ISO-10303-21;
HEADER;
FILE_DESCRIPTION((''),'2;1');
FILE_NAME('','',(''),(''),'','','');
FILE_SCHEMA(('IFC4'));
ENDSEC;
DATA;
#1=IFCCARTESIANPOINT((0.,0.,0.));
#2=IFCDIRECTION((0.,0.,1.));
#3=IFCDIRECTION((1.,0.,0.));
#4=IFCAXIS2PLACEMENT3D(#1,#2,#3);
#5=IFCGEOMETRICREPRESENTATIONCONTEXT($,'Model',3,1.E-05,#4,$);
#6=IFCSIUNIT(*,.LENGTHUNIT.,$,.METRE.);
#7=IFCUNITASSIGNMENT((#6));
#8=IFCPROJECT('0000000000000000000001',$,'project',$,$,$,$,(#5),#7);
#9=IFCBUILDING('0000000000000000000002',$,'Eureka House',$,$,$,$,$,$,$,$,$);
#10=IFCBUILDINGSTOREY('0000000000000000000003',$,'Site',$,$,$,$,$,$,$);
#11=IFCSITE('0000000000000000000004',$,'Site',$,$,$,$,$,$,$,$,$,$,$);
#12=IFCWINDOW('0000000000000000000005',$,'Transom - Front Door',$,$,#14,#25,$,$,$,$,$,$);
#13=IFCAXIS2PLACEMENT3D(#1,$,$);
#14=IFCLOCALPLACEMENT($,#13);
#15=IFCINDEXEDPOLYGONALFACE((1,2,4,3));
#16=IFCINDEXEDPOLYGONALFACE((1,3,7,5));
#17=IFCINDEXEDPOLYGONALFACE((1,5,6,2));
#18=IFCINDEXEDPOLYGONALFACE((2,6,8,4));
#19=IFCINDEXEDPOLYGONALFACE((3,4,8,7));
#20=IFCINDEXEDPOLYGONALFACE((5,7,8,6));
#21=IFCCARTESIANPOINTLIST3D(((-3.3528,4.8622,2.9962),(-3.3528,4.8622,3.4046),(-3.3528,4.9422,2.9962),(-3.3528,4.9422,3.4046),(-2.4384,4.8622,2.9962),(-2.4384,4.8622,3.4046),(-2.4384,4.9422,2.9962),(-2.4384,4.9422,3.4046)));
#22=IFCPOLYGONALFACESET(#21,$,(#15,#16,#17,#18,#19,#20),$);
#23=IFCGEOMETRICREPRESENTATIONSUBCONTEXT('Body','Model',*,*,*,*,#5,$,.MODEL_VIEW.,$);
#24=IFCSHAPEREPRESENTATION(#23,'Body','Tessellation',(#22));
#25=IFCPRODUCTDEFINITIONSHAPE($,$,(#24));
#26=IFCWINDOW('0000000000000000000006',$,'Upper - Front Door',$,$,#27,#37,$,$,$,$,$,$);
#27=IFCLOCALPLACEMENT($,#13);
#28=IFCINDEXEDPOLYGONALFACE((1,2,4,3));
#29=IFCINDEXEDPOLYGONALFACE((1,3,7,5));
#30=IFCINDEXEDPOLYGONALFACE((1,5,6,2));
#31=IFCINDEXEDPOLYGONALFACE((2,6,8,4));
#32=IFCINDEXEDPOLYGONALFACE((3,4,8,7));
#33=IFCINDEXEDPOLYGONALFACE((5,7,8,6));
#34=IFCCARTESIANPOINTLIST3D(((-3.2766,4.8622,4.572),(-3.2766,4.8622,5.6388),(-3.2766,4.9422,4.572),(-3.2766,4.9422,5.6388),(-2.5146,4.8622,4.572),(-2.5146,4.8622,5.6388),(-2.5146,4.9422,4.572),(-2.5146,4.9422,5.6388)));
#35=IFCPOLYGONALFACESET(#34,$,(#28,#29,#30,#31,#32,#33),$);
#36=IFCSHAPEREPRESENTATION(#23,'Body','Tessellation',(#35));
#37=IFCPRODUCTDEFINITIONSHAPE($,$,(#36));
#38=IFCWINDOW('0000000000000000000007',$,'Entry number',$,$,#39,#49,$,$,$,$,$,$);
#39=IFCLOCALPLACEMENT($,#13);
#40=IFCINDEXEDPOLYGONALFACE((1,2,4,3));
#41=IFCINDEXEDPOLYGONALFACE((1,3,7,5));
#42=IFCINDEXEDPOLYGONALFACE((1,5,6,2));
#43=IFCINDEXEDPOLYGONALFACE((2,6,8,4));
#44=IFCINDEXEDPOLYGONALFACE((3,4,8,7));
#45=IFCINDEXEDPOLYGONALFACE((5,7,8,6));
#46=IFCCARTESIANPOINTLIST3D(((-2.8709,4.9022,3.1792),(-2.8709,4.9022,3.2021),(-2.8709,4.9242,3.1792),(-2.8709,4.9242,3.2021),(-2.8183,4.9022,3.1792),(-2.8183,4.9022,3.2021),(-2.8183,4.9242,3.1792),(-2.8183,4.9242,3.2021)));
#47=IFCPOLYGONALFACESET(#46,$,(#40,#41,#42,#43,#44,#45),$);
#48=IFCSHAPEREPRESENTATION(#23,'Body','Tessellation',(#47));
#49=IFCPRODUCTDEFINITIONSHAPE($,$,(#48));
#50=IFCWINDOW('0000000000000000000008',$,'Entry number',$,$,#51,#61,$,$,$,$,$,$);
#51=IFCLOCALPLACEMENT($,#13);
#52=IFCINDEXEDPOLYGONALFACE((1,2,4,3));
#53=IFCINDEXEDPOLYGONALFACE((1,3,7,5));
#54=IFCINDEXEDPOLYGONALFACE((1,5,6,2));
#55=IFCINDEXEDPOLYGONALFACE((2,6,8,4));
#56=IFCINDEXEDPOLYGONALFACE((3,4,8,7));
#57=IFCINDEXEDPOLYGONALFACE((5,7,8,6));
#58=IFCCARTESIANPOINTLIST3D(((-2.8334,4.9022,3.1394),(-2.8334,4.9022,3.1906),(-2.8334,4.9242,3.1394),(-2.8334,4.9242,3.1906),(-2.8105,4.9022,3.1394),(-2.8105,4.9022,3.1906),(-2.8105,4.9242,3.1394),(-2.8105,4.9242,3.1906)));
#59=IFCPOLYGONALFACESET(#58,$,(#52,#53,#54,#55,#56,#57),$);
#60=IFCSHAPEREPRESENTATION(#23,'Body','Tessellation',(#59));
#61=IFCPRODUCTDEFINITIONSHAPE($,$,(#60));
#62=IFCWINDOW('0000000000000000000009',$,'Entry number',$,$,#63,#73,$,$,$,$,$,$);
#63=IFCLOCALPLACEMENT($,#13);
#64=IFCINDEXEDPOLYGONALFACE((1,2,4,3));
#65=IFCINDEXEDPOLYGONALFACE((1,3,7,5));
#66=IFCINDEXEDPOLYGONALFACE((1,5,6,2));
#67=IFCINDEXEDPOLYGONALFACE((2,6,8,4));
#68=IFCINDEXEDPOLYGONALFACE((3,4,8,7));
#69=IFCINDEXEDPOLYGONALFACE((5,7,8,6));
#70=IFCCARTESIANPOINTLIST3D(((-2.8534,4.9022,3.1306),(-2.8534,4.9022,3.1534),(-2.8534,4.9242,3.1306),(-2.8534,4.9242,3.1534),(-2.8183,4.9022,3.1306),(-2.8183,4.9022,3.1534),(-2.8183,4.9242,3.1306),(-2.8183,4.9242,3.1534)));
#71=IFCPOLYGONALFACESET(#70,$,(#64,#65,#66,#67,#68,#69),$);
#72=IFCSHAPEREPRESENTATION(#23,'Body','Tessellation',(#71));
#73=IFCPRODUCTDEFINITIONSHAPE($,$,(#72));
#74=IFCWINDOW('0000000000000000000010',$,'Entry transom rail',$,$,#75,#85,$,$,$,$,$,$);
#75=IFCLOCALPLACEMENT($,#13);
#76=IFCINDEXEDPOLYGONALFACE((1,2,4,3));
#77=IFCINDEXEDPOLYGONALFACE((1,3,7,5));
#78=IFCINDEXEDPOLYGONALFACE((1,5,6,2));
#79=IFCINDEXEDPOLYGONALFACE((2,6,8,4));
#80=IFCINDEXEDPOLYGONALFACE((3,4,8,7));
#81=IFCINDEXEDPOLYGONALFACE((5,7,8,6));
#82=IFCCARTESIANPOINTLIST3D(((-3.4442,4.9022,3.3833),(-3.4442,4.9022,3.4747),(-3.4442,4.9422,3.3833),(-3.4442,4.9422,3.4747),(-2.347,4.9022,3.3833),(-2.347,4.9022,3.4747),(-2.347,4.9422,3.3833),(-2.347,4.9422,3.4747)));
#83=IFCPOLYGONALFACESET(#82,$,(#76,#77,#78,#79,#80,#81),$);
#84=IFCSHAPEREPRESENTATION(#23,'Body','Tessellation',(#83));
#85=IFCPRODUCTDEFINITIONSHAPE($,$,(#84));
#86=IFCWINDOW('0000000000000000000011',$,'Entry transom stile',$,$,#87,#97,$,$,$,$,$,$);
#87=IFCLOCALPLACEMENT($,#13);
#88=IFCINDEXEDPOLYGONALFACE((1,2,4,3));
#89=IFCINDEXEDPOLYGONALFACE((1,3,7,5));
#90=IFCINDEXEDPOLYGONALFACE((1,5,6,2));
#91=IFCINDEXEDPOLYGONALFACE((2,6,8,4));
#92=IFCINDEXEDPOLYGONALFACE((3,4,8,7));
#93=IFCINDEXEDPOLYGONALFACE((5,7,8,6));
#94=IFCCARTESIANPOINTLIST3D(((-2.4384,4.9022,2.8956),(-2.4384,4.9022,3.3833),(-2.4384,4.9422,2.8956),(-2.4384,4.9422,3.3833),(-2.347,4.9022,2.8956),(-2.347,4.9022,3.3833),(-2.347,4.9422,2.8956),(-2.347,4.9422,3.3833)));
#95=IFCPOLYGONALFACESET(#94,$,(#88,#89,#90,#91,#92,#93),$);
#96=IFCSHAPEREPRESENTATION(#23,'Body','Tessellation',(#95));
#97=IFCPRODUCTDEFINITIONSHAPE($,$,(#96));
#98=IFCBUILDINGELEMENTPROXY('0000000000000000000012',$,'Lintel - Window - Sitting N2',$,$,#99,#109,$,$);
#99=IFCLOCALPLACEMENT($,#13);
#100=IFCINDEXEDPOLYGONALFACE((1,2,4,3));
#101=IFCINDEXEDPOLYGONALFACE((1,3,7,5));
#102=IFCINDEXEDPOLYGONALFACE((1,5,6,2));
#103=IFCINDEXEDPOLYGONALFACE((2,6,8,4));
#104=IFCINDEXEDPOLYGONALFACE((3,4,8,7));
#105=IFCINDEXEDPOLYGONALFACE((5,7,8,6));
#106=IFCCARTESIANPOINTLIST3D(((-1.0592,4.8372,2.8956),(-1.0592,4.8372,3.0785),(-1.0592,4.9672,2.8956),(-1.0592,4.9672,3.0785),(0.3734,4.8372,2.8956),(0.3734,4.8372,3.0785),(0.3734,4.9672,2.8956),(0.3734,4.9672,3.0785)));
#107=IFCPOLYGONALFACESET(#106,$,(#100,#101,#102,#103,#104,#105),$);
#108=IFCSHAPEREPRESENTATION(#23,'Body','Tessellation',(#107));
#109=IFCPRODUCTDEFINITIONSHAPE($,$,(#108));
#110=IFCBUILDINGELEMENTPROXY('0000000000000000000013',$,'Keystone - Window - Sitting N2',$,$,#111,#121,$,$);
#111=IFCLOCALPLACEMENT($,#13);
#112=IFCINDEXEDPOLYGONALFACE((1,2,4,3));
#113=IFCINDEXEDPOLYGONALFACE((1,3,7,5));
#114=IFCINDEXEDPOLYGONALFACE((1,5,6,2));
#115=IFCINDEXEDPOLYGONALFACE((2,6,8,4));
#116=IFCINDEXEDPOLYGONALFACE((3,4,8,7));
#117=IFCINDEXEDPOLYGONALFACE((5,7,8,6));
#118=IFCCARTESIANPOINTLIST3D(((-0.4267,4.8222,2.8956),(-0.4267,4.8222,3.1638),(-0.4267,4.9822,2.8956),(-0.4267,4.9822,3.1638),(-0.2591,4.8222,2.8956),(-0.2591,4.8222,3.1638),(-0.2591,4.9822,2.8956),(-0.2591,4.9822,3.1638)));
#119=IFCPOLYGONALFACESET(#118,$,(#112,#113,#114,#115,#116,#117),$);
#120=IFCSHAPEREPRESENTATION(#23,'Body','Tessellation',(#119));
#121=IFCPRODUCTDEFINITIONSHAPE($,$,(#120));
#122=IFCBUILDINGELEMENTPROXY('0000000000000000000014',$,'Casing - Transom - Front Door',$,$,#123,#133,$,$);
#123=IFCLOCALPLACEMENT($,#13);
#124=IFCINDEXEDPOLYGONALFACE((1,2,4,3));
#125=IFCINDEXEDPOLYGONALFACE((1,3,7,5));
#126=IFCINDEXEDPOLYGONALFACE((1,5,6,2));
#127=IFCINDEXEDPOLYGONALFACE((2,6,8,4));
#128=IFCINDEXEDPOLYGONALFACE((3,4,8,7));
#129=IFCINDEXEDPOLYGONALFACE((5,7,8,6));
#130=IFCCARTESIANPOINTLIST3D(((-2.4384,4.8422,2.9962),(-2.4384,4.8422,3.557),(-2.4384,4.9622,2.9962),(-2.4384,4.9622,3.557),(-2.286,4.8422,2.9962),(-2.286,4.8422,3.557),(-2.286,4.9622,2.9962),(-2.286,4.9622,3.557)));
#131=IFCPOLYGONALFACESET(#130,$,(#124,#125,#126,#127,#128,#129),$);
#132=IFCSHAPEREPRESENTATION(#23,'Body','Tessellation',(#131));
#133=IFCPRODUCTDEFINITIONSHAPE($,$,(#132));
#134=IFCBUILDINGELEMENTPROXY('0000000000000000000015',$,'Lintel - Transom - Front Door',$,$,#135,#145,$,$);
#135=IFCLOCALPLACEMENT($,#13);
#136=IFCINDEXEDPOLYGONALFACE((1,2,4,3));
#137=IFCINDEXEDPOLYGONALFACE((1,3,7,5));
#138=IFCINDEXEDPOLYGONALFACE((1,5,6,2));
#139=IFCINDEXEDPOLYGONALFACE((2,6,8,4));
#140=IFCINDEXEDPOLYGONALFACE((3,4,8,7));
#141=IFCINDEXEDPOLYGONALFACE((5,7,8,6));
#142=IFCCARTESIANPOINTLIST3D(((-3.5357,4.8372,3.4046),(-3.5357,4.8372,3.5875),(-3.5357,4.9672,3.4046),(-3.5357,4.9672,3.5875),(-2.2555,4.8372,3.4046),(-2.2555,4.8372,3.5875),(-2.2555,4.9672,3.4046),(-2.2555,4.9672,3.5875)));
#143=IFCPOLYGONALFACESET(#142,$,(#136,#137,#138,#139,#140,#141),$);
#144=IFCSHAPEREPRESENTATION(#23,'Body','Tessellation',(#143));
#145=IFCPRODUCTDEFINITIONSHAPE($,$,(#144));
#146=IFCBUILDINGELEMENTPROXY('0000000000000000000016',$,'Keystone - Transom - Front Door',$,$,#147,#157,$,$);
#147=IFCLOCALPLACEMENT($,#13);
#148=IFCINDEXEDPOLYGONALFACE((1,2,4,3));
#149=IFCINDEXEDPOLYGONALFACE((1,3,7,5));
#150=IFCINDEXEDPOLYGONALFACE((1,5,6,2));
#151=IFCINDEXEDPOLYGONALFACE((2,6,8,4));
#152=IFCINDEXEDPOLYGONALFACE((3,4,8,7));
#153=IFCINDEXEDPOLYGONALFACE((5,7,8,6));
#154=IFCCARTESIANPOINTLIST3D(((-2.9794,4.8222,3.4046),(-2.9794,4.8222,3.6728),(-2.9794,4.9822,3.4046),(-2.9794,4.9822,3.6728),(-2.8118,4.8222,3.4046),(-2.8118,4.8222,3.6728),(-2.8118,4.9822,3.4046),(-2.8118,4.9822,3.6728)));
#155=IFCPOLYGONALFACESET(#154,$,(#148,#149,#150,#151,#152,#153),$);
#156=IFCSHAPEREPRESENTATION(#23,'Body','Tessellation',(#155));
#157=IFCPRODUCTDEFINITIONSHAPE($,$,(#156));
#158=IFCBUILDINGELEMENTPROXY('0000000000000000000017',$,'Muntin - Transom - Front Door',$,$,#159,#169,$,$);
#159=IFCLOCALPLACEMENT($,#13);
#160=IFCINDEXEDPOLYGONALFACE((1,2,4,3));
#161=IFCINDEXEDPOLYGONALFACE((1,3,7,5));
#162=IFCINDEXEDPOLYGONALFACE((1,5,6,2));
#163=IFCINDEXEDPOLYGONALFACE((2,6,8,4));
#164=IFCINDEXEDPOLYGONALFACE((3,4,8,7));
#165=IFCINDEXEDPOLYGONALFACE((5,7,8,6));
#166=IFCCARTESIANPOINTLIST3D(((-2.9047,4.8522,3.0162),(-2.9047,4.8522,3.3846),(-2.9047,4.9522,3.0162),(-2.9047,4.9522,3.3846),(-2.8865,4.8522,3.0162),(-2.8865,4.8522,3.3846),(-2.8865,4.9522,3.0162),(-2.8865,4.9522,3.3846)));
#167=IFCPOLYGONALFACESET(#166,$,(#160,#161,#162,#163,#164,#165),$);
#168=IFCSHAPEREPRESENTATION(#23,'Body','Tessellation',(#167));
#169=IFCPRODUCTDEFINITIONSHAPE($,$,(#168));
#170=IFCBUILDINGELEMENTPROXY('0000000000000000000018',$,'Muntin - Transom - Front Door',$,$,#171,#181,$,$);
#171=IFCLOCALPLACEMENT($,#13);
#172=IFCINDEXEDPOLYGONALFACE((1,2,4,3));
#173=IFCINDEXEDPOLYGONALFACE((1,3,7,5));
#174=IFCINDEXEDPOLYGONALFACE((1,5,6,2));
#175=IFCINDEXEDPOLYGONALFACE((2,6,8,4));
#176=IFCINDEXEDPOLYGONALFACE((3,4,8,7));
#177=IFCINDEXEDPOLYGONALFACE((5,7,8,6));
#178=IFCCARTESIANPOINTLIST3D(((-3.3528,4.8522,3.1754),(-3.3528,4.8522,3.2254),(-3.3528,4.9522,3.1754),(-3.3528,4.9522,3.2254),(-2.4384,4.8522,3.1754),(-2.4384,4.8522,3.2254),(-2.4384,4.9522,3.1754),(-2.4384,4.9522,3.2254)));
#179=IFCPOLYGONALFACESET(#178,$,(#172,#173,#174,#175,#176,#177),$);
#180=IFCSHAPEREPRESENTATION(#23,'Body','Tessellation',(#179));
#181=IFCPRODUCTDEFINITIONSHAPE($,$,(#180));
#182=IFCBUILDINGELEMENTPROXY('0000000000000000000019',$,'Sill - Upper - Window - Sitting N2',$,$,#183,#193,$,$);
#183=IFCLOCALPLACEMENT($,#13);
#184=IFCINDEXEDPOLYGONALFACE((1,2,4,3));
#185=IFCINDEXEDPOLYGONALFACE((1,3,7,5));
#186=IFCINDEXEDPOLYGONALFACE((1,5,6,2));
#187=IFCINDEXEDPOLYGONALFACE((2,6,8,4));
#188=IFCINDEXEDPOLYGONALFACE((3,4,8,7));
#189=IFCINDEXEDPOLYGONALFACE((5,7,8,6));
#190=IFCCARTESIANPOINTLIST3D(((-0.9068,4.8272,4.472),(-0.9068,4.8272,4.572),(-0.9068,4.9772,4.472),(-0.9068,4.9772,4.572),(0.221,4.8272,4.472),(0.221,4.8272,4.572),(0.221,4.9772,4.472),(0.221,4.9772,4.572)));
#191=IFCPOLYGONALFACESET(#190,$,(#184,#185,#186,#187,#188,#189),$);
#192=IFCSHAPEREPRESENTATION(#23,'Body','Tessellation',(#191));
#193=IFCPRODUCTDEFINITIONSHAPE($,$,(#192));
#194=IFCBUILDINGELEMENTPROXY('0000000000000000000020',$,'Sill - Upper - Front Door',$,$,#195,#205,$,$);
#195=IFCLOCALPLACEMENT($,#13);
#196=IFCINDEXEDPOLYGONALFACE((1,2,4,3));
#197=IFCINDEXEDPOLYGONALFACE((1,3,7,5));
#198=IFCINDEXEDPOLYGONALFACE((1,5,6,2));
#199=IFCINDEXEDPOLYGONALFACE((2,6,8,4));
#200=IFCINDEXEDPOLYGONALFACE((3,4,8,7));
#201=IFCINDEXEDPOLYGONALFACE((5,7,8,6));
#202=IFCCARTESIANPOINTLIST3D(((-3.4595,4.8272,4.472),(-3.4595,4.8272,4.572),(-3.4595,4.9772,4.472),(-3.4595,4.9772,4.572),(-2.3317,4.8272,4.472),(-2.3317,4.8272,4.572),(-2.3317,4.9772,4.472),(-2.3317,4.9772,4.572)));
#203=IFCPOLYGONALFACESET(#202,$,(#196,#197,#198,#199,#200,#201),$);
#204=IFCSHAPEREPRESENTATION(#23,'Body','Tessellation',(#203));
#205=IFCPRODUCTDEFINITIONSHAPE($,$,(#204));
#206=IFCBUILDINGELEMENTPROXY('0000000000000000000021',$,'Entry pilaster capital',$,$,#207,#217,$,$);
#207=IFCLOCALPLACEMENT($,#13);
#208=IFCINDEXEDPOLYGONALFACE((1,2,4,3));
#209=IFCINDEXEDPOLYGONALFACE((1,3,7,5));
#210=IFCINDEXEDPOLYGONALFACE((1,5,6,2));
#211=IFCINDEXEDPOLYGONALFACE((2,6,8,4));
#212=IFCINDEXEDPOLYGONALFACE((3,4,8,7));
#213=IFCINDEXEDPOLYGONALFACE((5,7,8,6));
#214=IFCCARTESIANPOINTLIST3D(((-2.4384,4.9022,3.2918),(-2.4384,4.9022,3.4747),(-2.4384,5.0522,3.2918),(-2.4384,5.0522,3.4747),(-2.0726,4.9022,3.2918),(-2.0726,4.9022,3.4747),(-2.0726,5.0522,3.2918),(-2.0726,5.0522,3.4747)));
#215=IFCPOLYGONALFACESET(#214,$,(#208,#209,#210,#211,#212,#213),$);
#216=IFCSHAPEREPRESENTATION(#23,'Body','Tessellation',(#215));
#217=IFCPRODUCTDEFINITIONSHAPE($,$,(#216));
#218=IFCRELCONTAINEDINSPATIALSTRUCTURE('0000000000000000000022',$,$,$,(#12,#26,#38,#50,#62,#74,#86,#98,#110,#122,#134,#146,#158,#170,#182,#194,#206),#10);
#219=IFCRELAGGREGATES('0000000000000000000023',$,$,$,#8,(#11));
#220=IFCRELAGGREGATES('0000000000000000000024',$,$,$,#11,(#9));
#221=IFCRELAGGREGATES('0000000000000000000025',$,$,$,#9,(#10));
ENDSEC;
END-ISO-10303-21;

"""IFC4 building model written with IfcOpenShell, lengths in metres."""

from ifc_helpers import new_model, si_unit, frame, origin, origin_with_axes, origin_2d, place, context, subcontext, project, spatial, rectangle, extrude, element, save


model = new_model("IFC4")

# Units and contexts
model_context = context("Model", 3, precision=1e-05, world=origin_with_axes())
body_context = subcontext(model_context, "Body", "Model", "MODEL_VIEW")
ifc_project = project(units=[si_unit("LENGTHUNIT", "METRE")], contexts=[model_context])

# Site, building, storey
site = spatial("IfcSite", under=ifc_project, Name="Site")
building = spatial("IfcBuilding", under=site, Name="Eureka House")
storey = spatial("IfcBuildingStorey", under=building, Name="Site")

# Windows
window_1_placement = place(None, frame((-2.8956, 4.9022, 2.9962), z_axis=(0.0, 0.0, 1.0), x_axis=(1.0, 0.0, 0.0)))
element("IfcWindow", 1, at=window_1_placement, inside=storey, Name="Transom - Front Door", context=body_context, shape_type="SweptSolid", body=[
    extrude(rectangle(XDim=0.9144, YDim=0.08, at=origin_2d()), origin(), (0.0, 0.0, 1.0), 0.4084),
])
window_2_placement = place(None, frame((-2.8956, 4.9022, 4.572), z_axis=(0.0, 0.0, 1.0), x_axis=(1.0, 0.0, 0.0)))
element("IfcWindow", 2, at=window_2_placement, inside=storey, Name="Upper - Front Door", context=body_context, shape_type="SweptSolid", body=[
    extrude(rectangle(XDim=0.762, YDim=0.08, at=origin_2d()), origin(), (0.0, 0.0, 1.0), 1.0668),
])
window_3_placement = place(None, frame((-2.8446, 4.9132, 3.1792), z_axis=(0.0, 0.0, 1.0), x_axis=(1.0, 0.0, 0.0)))
element("IfcWindow", 3, at=window_3_placement, inside=storey, Name="Entry number", context=body_context, shape_type="SweptSolid", body=[
    extrude(rectangle(XDim=0.0527, YDim=0.022, at=origin_2d()), origin(), (0.0, 0.0, 1.0), 0.0229),
])
window_4_placement = place(None, frame((-2.8219, 4.9132, 3.1394), z_axis=(0.0, 0.0, 1.0), x_axis=(1.0, 0.0, 0.0)))
element("IfcWindow", 4, at=window_4_placement, inside=storey, Name="Entry number", context=body_context, shape_type="SweptSolid", body=[
    extrude(rectangle(XDim=0.0229, YDim=0.022, at=origin_2d()), origin(), (0.0, 0.0, 1.0), 0.0512),
])
window_5_placement = place(None, frame((-2.8358, 4.9132, 3.1306), z_axis=(0.0, 0.0, 1.0), x_axis=(1.0, 0.0, 0.0)))
element("IfcWindow", 5, at=window_5_placement, inside=storey, Name="Entry number", context=body_context, shape_type="SweptSolid", body=[
    extrude(rectangle(XDim=0.0351, YDim=0.022, at=origin_2d()), origin(), (0.0, 0.0, 1.0), 0.0229),
])
window_6_placement = place(None, frame((-2.8956, 4.9222, 3.3833), z_axis=(0.0, 0.0, 1.0), x_axis=(1.0, 0.0, 0.0)))
element("IfcWindow", 6, at=window_6_placement, inside=storey, Name="Entry transom rail", context=body_context, shape_type="SweptSolid", body=[
    extrude(rectangle(XDim=1.0973, YDim=0.04, at=origin_2d()), origin(), (0.0, 0.0, 1.0), 0.0914),
])
window_7_placement = place(None, frame((-2.3927, 4.9222, 2.8956), z_axis=(0.0, 0.0, 1.0), x_axis=(1.0, 0.0, 0.0)))
element("IfcWindow", 7, at=window_7_placement, inside=storey, Name="Entry transom stile", context=body_context, shape_type="SweptSolid", body=[
    extrude(rectangle(XDim=0.0914, YDim=0.04, at=origin_2d()), origin(), (0.0, 0.0, 1.0), 0.4877),
])

# Building element proxies
proxy_1_placement = place(None, frame((-0.3429, 4.9022, 2.8956), z_axis=(0.0, 0.0, 1.0), x_axis=(1.0, 0.0, 0.0)))
element("IfcBuildingElementProxy", 8, at=proxy_1_placement, inside=storey, Name="Lintel - Window - Sitting N2", context=body_context, shape_type="SweptSolid", body=[
    extrude(rectangle(XDim=1.4326, YDim=0.13, at=origin_2d()), origin(), (0.0, 0.0, 1.0), 0.1829),
])
proxy_2_placement = place(None, frame((-0.3429, 4.9022, 2.8956), z_axis=(0.0, 0.0, 1.0), x_axis=(1.0, 0.0, 0.0)))
element("IfcBuildingElementProxy", 9, at=proxy_2_placement, inside=storey, Name="Keystone - Window - Sitting N2", context=body_context, shape_type="SweptSolid", body=[
    extrude(rectangle(XDim=0.1676, YDim=0.16, at=origin_2d()), origin(), (0.0, 0.0, 1.0), 0.2682),
])
proxy_3_placement = place(None, frame((-2.3622, 4.9022, 2.9962), z_axis=(0.0, 0.0, 1.0), x_axis=(1.0, 0.0, 0.0)))
element("IfcBuildingElementProxy", 10, at=proxy_3_placement, inside=storey, Name="Casing - Transom - Front Door", context=body_context, shape_type="SweptSolid", body=[
    extrude(rectangle(XDim=0.1524, YDim=0.12, at=origin_2d()), origin(), (0.0, 0.0, 1.0), 0.5608),
])
proxy_4_placement = place(None, frame((-2.8956, 4.9022, 3.4046), z_axis=(0.0, 0.0, 1.0), x_axis=(1.0, 0.0, 0.0)))
element("IfcBuildingElementProxy", 11, at=proxy_4_placement, inside=storey, Name="Lintel - Transom - Front Door", context=body_context, shape_type="SweptSolid", body=[
    extrude(rectangle(XDim=1.2802, YDim=0.13, at=origin_2d()), origin(), (0.0, 0.0, 1.0), 0.1829),
])
proxy_5_placement = place(None, frame((-2.8956, 4.9022, 3.4046), z_axis=(0.0, 0.0, 1.0), x_axis=(1.0, 0.0, 0.0)))
element("IfcBuildingElementProxy", 12, at=proxy_5_placement, inside=storey, Name="Keystone - Transom - Front Door", context=body_context, shape_type="SweptSolid", body=[
    extrude(rectangle(XDim=0.1676, YDim=0.16, at=origin_2d()), origin(), (0.0, 0.0, 1.0), 0.2682),
])
proxy_6_placement = place(None, frame((-2.8956, 4.9022, 3.0162), z_axis=(0.0, 0.0, 1.0), x_axis=(1.0, 0.0, 0.0)))
element("IfcBuildingElementProxy", 13, at=proxy_6_placement, inside=storey, Name="Muntin - Transom - Front Door", context=body_context, shape_type="SweptSolid", body=[
    extrude(rectangle(XDim=0.0183, YDim=0.1, at=origin_2d()), origin(), (0.0, 0.0, 1.0), 0.3684),
])
proxy_7_placement = place(None, frame((-2.8956, 4.9022, 3.1754), z_axis=(0.0, 0.0, 1.0), x_axis=(1.0, 0.0, 0.0)))
element("IfcBuildingElementProxy", 14, at=proxy_7_placement, inside=storey, Name="Muntin - Transom - Front Door", context=body_context, shape_type="SweptSolid", body=[
    extrude(rectangle(XDim=0.9144, YDim=0.1, at=origin_2d()), origin(), (0.0, 0.0, 1.0), 0.05),
])
for number, where, z_axis, x_axis, name in (
    (15, (-0.3429, 4.9022, 4.472), (0.0, 0.0, 1.0), (1.0, 0.0, 0.0), "Sill - Upper - Window - Sitting N2"),
    (16, (-2.8956, 4.9022, 4.472), (0.0, 0.0, 1.0), (1.0, 0.0, 0.0), "Sill - Upper - Front Door"),
):
    element("IfcBuildingElementProxy", number, at=place(None, frame(where, z_axis=z_axis, x_axis=x_axis)), inside=storey, Name=name, context=body_context, shape_type="SweptSolid", body=[
        extrude(rectangle(XDim=1.1278, YDim=0.15, at=origin_2d()), origin(), (0.0, 0.0, 1.0), 0.1),
    ])
proxy_8_placement = place(None, frame((-2.2555, 4.9772, 3.2918), z_axis=(0.0, 0.0, 1.0), x_axis=(1.0, 0.0, 0.0)))
element("IfcBuildingElementProxy", 17, at=proxy_8_placement, inside=storey, Name="Entry pilaster capital", context=body_context, shape_type="SweptSolid", body=[
    extrude(rectangle(XDim=0.3658, YDim=0.15, at=origin_2d()), origin(), (0.0, 0.0, 1.0), 0.1829),
])

save(model, "model.ifc")
